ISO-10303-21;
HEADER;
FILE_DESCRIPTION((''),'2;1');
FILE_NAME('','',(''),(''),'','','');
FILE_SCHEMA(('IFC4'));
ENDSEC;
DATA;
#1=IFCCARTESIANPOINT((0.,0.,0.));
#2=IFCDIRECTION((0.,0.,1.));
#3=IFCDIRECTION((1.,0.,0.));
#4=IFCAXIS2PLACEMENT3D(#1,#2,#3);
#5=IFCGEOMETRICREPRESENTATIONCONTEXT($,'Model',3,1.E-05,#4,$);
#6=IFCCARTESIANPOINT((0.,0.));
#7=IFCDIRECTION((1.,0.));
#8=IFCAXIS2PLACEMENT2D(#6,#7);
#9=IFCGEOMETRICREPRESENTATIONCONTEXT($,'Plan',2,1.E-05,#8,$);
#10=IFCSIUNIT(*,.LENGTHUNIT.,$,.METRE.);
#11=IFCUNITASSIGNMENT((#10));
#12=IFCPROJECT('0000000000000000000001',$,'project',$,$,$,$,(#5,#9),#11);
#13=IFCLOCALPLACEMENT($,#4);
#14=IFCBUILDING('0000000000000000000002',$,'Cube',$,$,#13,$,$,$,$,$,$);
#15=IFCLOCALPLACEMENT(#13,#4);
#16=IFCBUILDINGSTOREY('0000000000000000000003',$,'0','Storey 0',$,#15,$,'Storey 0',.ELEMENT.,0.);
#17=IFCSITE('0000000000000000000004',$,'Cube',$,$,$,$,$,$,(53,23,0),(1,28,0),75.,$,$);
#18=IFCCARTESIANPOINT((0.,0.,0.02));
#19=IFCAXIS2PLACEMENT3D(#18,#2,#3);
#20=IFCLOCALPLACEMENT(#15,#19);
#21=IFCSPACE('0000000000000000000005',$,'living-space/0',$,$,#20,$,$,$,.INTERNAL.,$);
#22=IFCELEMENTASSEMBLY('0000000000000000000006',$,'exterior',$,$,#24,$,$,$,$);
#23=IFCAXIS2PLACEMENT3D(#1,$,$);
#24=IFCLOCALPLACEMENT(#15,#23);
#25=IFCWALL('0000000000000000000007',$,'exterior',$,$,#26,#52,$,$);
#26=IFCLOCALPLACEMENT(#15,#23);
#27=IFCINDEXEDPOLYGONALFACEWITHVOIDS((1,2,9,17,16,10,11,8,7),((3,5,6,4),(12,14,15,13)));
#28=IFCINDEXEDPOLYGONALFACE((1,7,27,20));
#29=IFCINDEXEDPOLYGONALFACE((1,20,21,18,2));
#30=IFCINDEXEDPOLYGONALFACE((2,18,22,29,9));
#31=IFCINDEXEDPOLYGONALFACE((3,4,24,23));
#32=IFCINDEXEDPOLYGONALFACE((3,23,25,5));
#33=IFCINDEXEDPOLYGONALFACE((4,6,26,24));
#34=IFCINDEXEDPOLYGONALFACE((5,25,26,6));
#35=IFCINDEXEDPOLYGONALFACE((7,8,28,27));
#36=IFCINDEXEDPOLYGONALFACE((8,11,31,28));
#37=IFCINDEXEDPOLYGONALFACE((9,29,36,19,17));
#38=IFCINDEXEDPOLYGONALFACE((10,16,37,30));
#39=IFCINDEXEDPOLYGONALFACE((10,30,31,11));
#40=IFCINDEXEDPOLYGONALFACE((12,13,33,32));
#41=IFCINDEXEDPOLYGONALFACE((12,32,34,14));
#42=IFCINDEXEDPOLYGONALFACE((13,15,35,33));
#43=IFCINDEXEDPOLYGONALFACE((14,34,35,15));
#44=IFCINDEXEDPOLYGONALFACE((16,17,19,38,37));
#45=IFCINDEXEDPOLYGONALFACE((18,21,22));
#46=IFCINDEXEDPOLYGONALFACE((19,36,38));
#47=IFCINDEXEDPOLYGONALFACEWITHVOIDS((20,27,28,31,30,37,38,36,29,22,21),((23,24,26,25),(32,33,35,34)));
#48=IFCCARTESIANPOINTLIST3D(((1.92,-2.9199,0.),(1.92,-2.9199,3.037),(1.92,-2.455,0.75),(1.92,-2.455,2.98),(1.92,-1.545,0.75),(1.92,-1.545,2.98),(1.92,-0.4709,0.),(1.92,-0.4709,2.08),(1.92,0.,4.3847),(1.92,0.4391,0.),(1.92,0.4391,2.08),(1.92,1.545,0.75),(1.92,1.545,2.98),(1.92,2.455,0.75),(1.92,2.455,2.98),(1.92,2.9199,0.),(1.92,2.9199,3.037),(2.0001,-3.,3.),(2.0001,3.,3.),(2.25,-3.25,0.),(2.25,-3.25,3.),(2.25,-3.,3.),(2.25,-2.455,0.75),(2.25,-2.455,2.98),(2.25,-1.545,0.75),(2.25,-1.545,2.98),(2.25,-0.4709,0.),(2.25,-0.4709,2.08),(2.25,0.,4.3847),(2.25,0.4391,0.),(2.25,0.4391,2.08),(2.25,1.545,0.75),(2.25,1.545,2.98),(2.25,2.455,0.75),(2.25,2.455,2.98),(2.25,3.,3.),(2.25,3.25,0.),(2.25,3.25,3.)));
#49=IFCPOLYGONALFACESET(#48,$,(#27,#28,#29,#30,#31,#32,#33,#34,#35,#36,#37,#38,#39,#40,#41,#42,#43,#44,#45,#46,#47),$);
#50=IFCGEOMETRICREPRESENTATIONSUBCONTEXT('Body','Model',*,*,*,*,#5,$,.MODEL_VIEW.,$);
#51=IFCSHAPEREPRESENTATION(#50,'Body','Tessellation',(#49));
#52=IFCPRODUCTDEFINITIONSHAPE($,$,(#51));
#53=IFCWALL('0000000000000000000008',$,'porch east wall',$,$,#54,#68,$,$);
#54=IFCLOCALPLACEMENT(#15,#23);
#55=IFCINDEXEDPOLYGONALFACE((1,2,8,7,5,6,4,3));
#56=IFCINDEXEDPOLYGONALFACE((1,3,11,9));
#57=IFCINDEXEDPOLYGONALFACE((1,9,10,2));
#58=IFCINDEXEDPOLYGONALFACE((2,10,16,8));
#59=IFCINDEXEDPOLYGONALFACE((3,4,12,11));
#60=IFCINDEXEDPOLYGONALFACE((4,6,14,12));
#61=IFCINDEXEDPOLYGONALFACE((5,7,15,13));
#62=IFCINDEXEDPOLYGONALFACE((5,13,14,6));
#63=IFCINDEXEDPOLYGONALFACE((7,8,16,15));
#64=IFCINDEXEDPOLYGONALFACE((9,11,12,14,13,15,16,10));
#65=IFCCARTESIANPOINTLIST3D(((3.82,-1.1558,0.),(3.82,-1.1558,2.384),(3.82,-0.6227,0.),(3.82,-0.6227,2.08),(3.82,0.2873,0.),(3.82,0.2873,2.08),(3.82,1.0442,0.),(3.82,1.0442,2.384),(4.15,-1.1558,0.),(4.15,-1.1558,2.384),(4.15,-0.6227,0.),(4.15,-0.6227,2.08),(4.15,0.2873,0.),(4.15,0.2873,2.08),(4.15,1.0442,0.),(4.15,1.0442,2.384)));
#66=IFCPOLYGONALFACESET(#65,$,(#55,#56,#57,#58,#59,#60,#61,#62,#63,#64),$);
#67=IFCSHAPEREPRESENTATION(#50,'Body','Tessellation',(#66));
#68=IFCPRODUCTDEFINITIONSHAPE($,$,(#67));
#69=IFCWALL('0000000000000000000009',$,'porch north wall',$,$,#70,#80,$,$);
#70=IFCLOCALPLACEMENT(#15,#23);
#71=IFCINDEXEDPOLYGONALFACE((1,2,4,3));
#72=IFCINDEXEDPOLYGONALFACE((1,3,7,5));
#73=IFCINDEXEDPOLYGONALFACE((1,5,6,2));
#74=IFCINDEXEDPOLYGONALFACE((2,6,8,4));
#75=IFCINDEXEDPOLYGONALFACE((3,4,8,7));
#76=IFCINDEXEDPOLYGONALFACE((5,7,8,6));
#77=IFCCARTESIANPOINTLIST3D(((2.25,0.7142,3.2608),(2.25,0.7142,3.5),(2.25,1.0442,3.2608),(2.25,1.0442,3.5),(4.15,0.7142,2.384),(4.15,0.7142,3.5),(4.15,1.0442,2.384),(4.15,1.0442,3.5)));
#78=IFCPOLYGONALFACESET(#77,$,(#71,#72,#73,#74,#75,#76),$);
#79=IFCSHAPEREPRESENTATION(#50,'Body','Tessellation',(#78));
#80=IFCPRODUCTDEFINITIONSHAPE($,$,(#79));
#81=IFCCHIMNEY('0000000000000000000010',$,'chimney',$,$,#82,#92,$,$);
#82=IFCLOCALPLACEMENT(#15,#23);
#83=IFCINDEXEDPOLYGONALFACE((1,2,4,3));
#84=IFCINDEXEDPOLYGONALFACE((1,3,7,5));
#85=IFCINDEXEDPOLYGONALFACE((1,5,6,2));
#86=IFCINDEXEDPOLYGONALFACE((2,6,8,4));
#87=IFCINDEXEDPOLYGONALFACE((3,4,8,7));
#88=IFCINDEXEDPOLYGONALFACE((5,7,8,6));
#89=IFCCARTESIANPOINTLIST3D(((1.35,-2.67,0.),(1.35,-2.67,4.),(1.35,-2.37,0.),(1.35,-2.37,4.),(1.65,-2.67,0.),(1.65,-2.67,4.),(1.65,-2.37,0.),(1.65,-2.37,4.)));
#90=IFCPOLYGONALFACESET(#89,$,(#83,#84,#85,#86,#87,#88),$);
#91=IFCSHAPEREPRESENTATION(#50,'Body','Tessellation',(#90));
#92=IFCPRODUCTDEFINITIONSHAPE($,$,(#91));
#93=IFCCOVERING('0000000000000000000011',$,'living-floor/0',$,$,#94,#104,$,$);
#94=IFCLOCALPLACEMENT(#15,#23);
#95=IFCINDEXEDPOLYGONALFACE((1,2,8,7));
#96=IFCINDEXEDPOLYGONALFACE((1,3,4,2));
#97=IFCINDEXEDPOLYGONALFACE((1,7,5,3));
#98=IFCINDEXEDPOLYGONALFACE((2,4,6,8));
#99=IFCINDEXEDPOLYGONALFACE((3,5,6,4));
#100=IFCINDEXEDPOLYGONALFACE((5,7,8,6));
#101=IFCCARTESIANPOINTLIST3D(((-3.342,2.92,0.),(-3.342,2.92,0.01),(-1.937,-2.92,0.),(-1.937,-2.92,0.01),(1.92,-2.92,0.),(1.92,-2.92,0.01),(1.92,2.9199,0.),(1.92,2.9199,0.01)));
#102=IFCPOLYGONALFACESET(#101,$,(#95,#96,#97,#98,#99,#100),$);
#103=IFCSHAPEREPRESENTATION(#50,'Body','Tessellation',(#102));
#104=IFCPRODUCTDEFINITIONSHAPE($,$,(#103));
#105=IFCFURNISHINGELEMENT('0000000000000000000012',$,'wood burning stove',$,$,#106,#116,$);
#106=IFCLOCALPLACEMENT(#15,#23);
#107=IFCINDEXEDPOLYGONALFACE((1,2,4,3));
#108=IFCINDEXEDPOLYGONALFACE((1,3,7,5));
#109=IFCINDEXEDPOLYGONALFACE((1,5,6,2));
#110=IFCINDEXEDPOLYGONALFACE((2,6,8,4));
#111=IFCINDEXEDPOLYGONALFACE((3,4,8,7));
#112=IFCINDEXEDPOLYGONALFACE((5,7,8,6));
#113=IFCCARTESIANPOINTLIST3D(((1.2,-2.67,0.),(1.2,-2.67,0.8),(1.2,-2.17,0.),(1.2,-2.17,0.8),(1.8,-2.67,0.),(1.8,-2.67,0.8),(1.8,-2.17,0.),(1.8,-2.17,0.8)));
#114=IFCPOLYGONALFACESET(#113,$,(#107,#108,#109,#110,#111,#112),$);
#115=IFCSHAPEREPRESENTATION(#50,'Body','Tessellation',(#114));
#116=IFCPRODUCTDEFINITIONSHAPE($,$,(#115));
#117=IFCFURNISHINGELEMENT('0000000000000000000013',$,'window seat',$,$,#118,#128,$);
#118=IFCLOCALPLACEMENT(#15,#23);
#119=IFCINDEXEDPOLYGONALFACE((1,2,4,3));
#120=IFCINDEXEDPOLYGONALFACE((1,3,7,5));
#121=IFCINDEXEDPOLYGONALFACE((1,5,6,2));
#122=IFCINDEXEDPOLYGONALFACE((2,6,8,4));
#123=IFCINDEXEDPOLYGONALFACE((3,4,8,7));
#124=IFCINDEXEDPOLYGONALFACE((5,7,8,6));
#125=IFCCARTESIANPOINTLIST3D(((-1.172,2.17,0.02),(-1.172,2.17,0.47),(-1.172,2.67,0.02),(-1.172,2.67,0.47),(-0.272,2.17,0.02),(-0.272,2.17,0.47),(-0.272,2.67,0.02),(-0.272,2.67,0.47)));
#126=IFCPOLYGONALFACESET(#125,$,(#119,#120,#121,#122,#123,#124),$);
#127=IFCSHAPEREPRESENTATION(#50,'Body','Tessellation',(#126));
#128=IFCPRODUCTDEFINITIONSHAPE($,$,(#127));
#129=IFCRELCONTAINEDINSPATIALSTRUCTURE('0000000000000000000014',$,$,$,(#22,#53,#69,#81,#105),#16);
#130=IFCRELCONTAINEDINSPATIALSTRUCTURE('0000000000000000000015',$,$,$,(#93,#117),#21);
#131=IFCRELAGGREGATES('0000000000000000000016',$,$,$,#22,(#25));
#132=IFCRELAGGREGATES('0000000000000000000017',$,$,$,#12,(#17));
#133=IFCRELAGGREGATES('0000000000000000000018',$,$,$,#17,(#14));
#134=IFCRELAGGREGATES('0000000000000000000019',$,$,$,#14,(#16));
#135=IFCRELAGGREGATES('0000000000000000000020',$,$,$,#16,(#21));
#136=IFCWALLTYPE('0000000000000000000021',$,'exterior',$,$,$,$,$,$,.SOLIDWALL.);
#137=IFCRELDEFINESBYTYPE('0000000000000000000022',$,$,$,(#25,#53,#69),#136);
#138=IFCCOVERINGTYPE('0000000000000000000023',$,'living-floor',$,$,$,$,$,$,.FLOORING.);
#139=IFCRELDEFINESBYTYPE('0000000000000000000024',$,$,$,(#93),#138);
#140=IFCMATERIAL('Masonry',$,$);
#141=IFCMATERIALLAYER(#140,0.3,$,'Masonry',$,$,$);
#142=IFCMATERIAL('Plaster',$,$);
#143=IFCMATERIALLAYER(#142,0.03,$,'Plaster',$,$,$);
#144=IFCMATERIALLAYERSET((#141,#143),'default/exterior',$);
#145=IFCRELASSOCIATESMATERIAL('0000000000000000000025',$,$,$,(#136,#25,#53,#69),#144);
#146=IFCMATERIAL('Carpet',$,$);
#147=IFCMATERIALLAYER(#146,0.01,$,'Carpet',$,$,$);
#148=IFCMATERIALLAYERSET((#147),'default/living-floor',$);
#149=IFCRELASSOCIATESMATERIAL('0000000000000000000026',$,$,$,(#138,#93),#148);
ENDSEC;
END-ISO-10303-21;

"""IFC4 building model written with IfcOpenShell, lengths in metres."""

from ifc_helpers import new_model, si_unit, frame, origin, origin_with_axes, origin_2d_with_axis, place, context, subcontext, project, spatial, polyline, line, indexed_curve, outline, extrude, clip, halfspace, bounded_halfspace, source, transform, mapped, material, layer, layer_set, layer_usage, type_object, element, aggregate, save


model = new_model("IFC4")

# Units and contexts
model_context = context("Model", 3, precision=1e-05, world=origin_with_axes())
plan_context = context("Plan", 2, precision=1e-05, world=origin_2d_with_axis())
body_context = subcontext(model_context, "Body", "Model", "MODEL_VIEW")
ifc_project = project(units=[si_unit("LENGTHUNIT", "METRE")], contexts=[model_context, plan_context])

# Site, building, storey
site = spatial("IfcSite", under=ifc_project, Name="Cube", RefLatitude=(53, 23, 0), RefLongitude=(1, 28, 0), RefElevation=75.0)
building_placement = place(None, origin_with_axes())
building = spatial("IfcBuilding", under=site, at=building_placement, Name="Cube")
storey_placement = place(building_placement, origin_with_axes())
storey = spatial("IfcBuildingStorey", under=building, at=storey_placement, Name="0", Description="Storey 0", LongName="Storey 0", CompositionType="ELEMENT", Elevation=0.0)

# Element assembly, wall, openings
ifc_material_1 = material(Name="Masonry")
ifc_layer_1 = layer(ifc_material_1, 0.3, Name="Masonry")
ifc_material_2 = material(Name="Plaster")
ifc_layer_2 = layer(ifc_material_2, 0.03, Name="Plaster")
ifc_layer_set_1 = layer_set([ifc_layer_1, ifc_layer_2], Name="default/exterior")
wall_type = type_object("IfcWallType", Name="exterior", PredefinedType="SOLIDWALL", material=ifc_layer_set_1)
assembly_1_placement = place(storey_placement, frame((2.0, -3.0, 0.0), z_axis=(0.0, 0.0, 1.0), x_axis=(0.0, 1.0, 0.0)))
assembly_1 = element("IfcElementAssembly", 1, at=assembly_1_placement, inside=storey, Name="exterior")
ifc_layer_usage_1 = layer_usage(ifc_layer_set_1, "AXIS2", "POSITIVE", -0.25)
wall_1_placement = place(assembly_1_placement, origin_with_axes())
wall_1 = element("IfcWall", 2, at=wall_1_placement, type_object=wall_type, material=ifc_layer_usage_1, Name="exterior", context=body_context, shape_type="Clipping", body=[
    clip(clip(clip(clip(extrude(outline(polyline([(0.0801, 0.08), (-0.25, -0.25), (6.25, -0.25), (5.9199, 0.08), (0.0801, 0.08)])), origin(), (0.0, 0.0, 1.0), 4.385), bounded_halfspace(frame((6.0, 0.0, 3.0), z_axis=(0.419069, 0.0, 0.907954), x_axis=(0.0, -1.0, 0.0)), False, origin(), polyline([(6.0, -1.0), (3.0, -1.0), (3.0, 1.0), (6.0, 1.0), (6.0, -1.0)]))), bounded_halfspace(frame((6.0, 0.0, 3.0), z_axis=(0.0, 0.0, 1.0), x_axis=(0.0, 1.0, 0.0)), False, origin(), polyline([(6.0, 1.0), (7.0, 1.0), (7.0, -1.0), (6.0, -1.0), (6.0, 1.0)]))), bounded_halfspace(frame((3.0, 0.0, 4.3847), z_axis=(-0.419069, 0.0, 0.907954), x_axis=(0.0, -1.0, 0.0)), False, origin(), polyline([(3.0, -1.0), (0.0, -1.0), (0.0, 1.0), (3.0, 1.0), (3.0, -1.0)]))), bounded_halfspace(frame((0.0, 0.0, 3.0), z_axis=(0.0, 0.0, 1.0), x_axis=(0.0, -1.0, 0.0)), False, origin(), polyline([(0.0, -1.0), (-1.0, -1.0), (-1.0, 1.0), (0.0, 1.0), (0.0, -1.0)]))),
])
opening_1_placement = place(wall_1_placement, frame((0.545, -0.25, 0.75), z_axis=(0.0, 0.0, 1.0), x_axis=(1.0, 0.0, 0.0)))
element("IfcOpeningElement", 3, at=opening_1_placement, cuts=wall_1, PredefinedType="OPENING", context=body_context, shape_type="SweptSolid", body=[
    extrude(outline(polyline([(0.0, -0.02), (0.91, -0.02), (0.91, 0.35), (0.0, 0.35), (0.0, -0.02)])), origin(), (0.0, 0.0, 1.0), 2.23),
])
opening_2_placement = place(wall_1_placement, frame((4.545, -0.25, 0.75), z_axis=(0.0, 0.0, 1.0), x_axis=(1.0, 0.0, 0.0)))
element("IfcOpeningElement", 4, at=opening_2_placement, cuts=wall_1, PredefinedType="OPENING", context=body_context, shape_type="SweptSolid", body=[
    extrude(outline(polyline([(0.0, -0.02), (0.91, -0.02), (0.91, 0.35), (0.0, 0.35), (0.0, -0.02)])), origin(), (0.0, 0.0, 1.0), 2.23),
])
shared_shape_1 = source(origin_with_axes(), body_context, "Body", "SweptSolid", [
    extrude(outline(indexed_curve([(0.0, 0.0), (0.91, 0.0), (0.91, 2.08), (0.0, 2.08)], segments=[line(1, 2, 3, 4, 1)])), frame((0.0, -0.6, 0.0), z_axis=(0.0, -1.0, 0.0), x_axis=(1.0, 0.0, 0.0)), (0.0, 0.0, -1.0), 1.2),
])
opening_3_placement = place(wall_1_placement, frame((2.5291, -0.25, 0.0), z_axis=(0.0, 0.0, 1.0), x_axis=(1.0, 0.0, 0.0)))
element("IfcOpeningElement", 5, at=opening_3_placement, cuts=wall_1, PredefinedType="OPENING", context=body_context, shape_type="MappedRepresentation", body=[
    mapped(shared_shape_1, transform((0.0, 0.0, 0.0), x_axis=(1.0, 0.0, 0.0), y_axis=(0.0, 1.0, 0.0), z_axis=(0.0, 0.0, 1.0), scale=1.0)),
])
aggregate(assembly_1, [wall_1])

# Wall, opening
ifc_layer_usage_2 = layer_usage(ifc_layer_set_1, "AXIS2", "POSITIVE", 0.0)
wall_2_placement = place(storey_placement, frame((4.15, -1.1558, 0.0), z_axis=(0.0, 0.0, 1.0), x_axis=(0.0, 1.0, 0.0)))
wall_2 = element("IfcWall", 6, at=wall_2_placement, inside=storey, type_object=wall_type, material=ifc_layer_usage_2, Name="porch east wall", context=body_context, shape_type="SweptSolid", body=[
    extrude(outline(indexed_curve([(0.0, 0.0), (0.0, 0.33), (2.2, 0.33), (2.2, 0.0), (0.0, 0.0)], self_intersect=False)), origin_with_axes(), (0.0, 0.0, 1.0), 2.384),
])
shared_shape_2 = source(origin_with_axes(), body_context, "Body", "SweptSolid", [
    extrude(outline(indexed_curve([(0.0, 0.0), (0.91, 0.0), (0.91, 2.08), (0.0, 2.08)], segments=[line(1, 2, 3, 4, 1)])), frame((0.0, -0.6, 0.0), z_axis=(0.0, -1.0, 0.0), x_axis=(1.0, 0.0, 0.0)), (0.0, 0.0, -1.0), 1.2),
])
opening_4_placement = place(wall_2_placement, frame((0.5331, 0.0, 0.0), z_axis=(0.0, 0.0, 1.0), x_axis=(1.0, 0.0, 0.0)))
element("IfcOpeningElement", 7, at=opening_4_placement, cuts=wall_2, PredefinedType="OPENING", context=body_context, shape_type="MappedRepresentation", body=[
    mapped(shared_shape_2, transform((0.0, 0.0, 0.0), x_axis=(1.0, 0.0, 0.0), y_axis=(0.0, 1.0, 0.0), z_axis=(0.0, 0.0, 1.0), scale=1.0)),
])

# Wall
ifc_layer_usage_3 = layer_usage(ifc_layer_set_1, "AXIS2", "POSITIVE", 0.0)
wall_3_placement = place(storey_placement, frame((4.15, 1.0442, 0.0), z_axis=(0.0, 0.0, 1.0), x_axis=(-1.0, 0.0, 0.0)))
element("IfcWall", 8, at=wall_3_placement, inside=storey, type_object=wall_type, material=ifc_layer_usage_3, Name="porch north wall", context=body_context, shape_type="Clipping", body=[
    clip(extrude(outline(indexed_curve([(0.0, 0.0), (0.0, 0.33), (1.9, 0.33), (1.9, 0.0), (0.0, 0.0)], self_intersect=False)), origin_with_axes(), (0.0, 0.0, 1.0), 3.5), halfspace(frame((0.0, 0.0, 2.384), z_axis=(0.419, 0.0, -0.908), x_axis=(0.0, -1.0, 0.0)), False)),
])

# Chimney
chimney_placement = place(storey_placement, frame((1.35, -2.67, 0.0), z_axis=(0.0, 0.0, 1.0), x_axis=(1.0, 0.0, 0.0)))
element("IfcChimney", 9, at=chimney_placement, inside=storey, Name="chimney", context=body_context, shape_type="SweptSolid", body=[
    extrude(outline(indexed_curve([(0.0, 0.0), (0.3, 0.0), (0.3, 0.3), (0.0, 0.3)])), None, (0.0, 0.0, 1.0), 4.0),
])

# Shared definitions
space_placement = place(storey_placement, frame((0.0, 0.0, 0.02), z_axis=(0.0, 0.0, 1.0), x_axis=(1.0, 0.0, 0.0)))
space = spatial("IfcSpace", under=storey, at=space_placement, Name="living-space/0", PredefinedType="INTERNAL")

# Covering
ifc_material_3 = material(Name="Carpet")
ifc_layer_3 = layer(ifc_material_3, 0.01, Name="Carpet")
ifc_layer_set_2 = layer_set([ifc_layer_3], Name="default/living-floor")
ifc_layer_usage_4 = layer_usage(ifc_layer_set_2, "AXIS3", "POSITIVE", 0.0)
covering_type = type_object("IfcCoveringType", Name="living-floor", PredefinedType="FLOORING", material=ifc_layer_set_2)
covering_placement = place(space_placement, frame((0.0, 0.0, -0.02), z_axis=(0.0, 0.0, 1.0), x_axis=(1.0, 0.0, 0.0)))
element("IfcCovering", 10, at=covering_placement, inside=space, type_object=covering_type, material=ifc_layer_usage_4, Name="living-floor/0", context=body_context, shape_type="SweptSolid", body=[
    extrude(outline(polyline([(1.92, 2.9199), (-3.342, 2.92), (-1.937, -2.92), (1.92, -2.92), (1.92, 2.9199)])), origin_with_axes(), (0.0, 0.0, 1.0), 0.01),
])

# Furnishing elements
furnishing_1_placement = place(storey_placement, frame((1.2, -2.67, 0.0), z_axis=(0.0, 0.0, 1.0), x_axis=(1.0, 0.0, 0.0)))
element("IfcFurnishingElement", 11, at=furnishing_1_placement, inside=storey, Name="wood burning stove", context=body_context, shape_type="SweptSolid", body=[
    extrude(outline(indexed_curve([(0.0, 0.0), (0.6, 0.0), (0.6, 0.5), (0.0, 0.5)])), None, (0.0, 0.0, 1.0), 0.8),
])
furnishing_2_placement = place(space_placement, frame((-1.172, 2.17, 0.0), z_axis=(0.0, 0.0, 1.0), x_axis=(1.0, 0.0, 0.0)))
element("IfcFurnishingElement", 12, at=furnishing_2_placement, inside=space, Name="window seat", context=body_context, shape_type="SweptSolid", body=[
    extrude(outline(indexed_curve([(0.0, 0.0), (0.9, 0.0), (0.9, 0.5), (0.0, 0.5)])), None, (0.0, 0.0, 1.0), 0.45),
])

save(model, "model.ifc")
